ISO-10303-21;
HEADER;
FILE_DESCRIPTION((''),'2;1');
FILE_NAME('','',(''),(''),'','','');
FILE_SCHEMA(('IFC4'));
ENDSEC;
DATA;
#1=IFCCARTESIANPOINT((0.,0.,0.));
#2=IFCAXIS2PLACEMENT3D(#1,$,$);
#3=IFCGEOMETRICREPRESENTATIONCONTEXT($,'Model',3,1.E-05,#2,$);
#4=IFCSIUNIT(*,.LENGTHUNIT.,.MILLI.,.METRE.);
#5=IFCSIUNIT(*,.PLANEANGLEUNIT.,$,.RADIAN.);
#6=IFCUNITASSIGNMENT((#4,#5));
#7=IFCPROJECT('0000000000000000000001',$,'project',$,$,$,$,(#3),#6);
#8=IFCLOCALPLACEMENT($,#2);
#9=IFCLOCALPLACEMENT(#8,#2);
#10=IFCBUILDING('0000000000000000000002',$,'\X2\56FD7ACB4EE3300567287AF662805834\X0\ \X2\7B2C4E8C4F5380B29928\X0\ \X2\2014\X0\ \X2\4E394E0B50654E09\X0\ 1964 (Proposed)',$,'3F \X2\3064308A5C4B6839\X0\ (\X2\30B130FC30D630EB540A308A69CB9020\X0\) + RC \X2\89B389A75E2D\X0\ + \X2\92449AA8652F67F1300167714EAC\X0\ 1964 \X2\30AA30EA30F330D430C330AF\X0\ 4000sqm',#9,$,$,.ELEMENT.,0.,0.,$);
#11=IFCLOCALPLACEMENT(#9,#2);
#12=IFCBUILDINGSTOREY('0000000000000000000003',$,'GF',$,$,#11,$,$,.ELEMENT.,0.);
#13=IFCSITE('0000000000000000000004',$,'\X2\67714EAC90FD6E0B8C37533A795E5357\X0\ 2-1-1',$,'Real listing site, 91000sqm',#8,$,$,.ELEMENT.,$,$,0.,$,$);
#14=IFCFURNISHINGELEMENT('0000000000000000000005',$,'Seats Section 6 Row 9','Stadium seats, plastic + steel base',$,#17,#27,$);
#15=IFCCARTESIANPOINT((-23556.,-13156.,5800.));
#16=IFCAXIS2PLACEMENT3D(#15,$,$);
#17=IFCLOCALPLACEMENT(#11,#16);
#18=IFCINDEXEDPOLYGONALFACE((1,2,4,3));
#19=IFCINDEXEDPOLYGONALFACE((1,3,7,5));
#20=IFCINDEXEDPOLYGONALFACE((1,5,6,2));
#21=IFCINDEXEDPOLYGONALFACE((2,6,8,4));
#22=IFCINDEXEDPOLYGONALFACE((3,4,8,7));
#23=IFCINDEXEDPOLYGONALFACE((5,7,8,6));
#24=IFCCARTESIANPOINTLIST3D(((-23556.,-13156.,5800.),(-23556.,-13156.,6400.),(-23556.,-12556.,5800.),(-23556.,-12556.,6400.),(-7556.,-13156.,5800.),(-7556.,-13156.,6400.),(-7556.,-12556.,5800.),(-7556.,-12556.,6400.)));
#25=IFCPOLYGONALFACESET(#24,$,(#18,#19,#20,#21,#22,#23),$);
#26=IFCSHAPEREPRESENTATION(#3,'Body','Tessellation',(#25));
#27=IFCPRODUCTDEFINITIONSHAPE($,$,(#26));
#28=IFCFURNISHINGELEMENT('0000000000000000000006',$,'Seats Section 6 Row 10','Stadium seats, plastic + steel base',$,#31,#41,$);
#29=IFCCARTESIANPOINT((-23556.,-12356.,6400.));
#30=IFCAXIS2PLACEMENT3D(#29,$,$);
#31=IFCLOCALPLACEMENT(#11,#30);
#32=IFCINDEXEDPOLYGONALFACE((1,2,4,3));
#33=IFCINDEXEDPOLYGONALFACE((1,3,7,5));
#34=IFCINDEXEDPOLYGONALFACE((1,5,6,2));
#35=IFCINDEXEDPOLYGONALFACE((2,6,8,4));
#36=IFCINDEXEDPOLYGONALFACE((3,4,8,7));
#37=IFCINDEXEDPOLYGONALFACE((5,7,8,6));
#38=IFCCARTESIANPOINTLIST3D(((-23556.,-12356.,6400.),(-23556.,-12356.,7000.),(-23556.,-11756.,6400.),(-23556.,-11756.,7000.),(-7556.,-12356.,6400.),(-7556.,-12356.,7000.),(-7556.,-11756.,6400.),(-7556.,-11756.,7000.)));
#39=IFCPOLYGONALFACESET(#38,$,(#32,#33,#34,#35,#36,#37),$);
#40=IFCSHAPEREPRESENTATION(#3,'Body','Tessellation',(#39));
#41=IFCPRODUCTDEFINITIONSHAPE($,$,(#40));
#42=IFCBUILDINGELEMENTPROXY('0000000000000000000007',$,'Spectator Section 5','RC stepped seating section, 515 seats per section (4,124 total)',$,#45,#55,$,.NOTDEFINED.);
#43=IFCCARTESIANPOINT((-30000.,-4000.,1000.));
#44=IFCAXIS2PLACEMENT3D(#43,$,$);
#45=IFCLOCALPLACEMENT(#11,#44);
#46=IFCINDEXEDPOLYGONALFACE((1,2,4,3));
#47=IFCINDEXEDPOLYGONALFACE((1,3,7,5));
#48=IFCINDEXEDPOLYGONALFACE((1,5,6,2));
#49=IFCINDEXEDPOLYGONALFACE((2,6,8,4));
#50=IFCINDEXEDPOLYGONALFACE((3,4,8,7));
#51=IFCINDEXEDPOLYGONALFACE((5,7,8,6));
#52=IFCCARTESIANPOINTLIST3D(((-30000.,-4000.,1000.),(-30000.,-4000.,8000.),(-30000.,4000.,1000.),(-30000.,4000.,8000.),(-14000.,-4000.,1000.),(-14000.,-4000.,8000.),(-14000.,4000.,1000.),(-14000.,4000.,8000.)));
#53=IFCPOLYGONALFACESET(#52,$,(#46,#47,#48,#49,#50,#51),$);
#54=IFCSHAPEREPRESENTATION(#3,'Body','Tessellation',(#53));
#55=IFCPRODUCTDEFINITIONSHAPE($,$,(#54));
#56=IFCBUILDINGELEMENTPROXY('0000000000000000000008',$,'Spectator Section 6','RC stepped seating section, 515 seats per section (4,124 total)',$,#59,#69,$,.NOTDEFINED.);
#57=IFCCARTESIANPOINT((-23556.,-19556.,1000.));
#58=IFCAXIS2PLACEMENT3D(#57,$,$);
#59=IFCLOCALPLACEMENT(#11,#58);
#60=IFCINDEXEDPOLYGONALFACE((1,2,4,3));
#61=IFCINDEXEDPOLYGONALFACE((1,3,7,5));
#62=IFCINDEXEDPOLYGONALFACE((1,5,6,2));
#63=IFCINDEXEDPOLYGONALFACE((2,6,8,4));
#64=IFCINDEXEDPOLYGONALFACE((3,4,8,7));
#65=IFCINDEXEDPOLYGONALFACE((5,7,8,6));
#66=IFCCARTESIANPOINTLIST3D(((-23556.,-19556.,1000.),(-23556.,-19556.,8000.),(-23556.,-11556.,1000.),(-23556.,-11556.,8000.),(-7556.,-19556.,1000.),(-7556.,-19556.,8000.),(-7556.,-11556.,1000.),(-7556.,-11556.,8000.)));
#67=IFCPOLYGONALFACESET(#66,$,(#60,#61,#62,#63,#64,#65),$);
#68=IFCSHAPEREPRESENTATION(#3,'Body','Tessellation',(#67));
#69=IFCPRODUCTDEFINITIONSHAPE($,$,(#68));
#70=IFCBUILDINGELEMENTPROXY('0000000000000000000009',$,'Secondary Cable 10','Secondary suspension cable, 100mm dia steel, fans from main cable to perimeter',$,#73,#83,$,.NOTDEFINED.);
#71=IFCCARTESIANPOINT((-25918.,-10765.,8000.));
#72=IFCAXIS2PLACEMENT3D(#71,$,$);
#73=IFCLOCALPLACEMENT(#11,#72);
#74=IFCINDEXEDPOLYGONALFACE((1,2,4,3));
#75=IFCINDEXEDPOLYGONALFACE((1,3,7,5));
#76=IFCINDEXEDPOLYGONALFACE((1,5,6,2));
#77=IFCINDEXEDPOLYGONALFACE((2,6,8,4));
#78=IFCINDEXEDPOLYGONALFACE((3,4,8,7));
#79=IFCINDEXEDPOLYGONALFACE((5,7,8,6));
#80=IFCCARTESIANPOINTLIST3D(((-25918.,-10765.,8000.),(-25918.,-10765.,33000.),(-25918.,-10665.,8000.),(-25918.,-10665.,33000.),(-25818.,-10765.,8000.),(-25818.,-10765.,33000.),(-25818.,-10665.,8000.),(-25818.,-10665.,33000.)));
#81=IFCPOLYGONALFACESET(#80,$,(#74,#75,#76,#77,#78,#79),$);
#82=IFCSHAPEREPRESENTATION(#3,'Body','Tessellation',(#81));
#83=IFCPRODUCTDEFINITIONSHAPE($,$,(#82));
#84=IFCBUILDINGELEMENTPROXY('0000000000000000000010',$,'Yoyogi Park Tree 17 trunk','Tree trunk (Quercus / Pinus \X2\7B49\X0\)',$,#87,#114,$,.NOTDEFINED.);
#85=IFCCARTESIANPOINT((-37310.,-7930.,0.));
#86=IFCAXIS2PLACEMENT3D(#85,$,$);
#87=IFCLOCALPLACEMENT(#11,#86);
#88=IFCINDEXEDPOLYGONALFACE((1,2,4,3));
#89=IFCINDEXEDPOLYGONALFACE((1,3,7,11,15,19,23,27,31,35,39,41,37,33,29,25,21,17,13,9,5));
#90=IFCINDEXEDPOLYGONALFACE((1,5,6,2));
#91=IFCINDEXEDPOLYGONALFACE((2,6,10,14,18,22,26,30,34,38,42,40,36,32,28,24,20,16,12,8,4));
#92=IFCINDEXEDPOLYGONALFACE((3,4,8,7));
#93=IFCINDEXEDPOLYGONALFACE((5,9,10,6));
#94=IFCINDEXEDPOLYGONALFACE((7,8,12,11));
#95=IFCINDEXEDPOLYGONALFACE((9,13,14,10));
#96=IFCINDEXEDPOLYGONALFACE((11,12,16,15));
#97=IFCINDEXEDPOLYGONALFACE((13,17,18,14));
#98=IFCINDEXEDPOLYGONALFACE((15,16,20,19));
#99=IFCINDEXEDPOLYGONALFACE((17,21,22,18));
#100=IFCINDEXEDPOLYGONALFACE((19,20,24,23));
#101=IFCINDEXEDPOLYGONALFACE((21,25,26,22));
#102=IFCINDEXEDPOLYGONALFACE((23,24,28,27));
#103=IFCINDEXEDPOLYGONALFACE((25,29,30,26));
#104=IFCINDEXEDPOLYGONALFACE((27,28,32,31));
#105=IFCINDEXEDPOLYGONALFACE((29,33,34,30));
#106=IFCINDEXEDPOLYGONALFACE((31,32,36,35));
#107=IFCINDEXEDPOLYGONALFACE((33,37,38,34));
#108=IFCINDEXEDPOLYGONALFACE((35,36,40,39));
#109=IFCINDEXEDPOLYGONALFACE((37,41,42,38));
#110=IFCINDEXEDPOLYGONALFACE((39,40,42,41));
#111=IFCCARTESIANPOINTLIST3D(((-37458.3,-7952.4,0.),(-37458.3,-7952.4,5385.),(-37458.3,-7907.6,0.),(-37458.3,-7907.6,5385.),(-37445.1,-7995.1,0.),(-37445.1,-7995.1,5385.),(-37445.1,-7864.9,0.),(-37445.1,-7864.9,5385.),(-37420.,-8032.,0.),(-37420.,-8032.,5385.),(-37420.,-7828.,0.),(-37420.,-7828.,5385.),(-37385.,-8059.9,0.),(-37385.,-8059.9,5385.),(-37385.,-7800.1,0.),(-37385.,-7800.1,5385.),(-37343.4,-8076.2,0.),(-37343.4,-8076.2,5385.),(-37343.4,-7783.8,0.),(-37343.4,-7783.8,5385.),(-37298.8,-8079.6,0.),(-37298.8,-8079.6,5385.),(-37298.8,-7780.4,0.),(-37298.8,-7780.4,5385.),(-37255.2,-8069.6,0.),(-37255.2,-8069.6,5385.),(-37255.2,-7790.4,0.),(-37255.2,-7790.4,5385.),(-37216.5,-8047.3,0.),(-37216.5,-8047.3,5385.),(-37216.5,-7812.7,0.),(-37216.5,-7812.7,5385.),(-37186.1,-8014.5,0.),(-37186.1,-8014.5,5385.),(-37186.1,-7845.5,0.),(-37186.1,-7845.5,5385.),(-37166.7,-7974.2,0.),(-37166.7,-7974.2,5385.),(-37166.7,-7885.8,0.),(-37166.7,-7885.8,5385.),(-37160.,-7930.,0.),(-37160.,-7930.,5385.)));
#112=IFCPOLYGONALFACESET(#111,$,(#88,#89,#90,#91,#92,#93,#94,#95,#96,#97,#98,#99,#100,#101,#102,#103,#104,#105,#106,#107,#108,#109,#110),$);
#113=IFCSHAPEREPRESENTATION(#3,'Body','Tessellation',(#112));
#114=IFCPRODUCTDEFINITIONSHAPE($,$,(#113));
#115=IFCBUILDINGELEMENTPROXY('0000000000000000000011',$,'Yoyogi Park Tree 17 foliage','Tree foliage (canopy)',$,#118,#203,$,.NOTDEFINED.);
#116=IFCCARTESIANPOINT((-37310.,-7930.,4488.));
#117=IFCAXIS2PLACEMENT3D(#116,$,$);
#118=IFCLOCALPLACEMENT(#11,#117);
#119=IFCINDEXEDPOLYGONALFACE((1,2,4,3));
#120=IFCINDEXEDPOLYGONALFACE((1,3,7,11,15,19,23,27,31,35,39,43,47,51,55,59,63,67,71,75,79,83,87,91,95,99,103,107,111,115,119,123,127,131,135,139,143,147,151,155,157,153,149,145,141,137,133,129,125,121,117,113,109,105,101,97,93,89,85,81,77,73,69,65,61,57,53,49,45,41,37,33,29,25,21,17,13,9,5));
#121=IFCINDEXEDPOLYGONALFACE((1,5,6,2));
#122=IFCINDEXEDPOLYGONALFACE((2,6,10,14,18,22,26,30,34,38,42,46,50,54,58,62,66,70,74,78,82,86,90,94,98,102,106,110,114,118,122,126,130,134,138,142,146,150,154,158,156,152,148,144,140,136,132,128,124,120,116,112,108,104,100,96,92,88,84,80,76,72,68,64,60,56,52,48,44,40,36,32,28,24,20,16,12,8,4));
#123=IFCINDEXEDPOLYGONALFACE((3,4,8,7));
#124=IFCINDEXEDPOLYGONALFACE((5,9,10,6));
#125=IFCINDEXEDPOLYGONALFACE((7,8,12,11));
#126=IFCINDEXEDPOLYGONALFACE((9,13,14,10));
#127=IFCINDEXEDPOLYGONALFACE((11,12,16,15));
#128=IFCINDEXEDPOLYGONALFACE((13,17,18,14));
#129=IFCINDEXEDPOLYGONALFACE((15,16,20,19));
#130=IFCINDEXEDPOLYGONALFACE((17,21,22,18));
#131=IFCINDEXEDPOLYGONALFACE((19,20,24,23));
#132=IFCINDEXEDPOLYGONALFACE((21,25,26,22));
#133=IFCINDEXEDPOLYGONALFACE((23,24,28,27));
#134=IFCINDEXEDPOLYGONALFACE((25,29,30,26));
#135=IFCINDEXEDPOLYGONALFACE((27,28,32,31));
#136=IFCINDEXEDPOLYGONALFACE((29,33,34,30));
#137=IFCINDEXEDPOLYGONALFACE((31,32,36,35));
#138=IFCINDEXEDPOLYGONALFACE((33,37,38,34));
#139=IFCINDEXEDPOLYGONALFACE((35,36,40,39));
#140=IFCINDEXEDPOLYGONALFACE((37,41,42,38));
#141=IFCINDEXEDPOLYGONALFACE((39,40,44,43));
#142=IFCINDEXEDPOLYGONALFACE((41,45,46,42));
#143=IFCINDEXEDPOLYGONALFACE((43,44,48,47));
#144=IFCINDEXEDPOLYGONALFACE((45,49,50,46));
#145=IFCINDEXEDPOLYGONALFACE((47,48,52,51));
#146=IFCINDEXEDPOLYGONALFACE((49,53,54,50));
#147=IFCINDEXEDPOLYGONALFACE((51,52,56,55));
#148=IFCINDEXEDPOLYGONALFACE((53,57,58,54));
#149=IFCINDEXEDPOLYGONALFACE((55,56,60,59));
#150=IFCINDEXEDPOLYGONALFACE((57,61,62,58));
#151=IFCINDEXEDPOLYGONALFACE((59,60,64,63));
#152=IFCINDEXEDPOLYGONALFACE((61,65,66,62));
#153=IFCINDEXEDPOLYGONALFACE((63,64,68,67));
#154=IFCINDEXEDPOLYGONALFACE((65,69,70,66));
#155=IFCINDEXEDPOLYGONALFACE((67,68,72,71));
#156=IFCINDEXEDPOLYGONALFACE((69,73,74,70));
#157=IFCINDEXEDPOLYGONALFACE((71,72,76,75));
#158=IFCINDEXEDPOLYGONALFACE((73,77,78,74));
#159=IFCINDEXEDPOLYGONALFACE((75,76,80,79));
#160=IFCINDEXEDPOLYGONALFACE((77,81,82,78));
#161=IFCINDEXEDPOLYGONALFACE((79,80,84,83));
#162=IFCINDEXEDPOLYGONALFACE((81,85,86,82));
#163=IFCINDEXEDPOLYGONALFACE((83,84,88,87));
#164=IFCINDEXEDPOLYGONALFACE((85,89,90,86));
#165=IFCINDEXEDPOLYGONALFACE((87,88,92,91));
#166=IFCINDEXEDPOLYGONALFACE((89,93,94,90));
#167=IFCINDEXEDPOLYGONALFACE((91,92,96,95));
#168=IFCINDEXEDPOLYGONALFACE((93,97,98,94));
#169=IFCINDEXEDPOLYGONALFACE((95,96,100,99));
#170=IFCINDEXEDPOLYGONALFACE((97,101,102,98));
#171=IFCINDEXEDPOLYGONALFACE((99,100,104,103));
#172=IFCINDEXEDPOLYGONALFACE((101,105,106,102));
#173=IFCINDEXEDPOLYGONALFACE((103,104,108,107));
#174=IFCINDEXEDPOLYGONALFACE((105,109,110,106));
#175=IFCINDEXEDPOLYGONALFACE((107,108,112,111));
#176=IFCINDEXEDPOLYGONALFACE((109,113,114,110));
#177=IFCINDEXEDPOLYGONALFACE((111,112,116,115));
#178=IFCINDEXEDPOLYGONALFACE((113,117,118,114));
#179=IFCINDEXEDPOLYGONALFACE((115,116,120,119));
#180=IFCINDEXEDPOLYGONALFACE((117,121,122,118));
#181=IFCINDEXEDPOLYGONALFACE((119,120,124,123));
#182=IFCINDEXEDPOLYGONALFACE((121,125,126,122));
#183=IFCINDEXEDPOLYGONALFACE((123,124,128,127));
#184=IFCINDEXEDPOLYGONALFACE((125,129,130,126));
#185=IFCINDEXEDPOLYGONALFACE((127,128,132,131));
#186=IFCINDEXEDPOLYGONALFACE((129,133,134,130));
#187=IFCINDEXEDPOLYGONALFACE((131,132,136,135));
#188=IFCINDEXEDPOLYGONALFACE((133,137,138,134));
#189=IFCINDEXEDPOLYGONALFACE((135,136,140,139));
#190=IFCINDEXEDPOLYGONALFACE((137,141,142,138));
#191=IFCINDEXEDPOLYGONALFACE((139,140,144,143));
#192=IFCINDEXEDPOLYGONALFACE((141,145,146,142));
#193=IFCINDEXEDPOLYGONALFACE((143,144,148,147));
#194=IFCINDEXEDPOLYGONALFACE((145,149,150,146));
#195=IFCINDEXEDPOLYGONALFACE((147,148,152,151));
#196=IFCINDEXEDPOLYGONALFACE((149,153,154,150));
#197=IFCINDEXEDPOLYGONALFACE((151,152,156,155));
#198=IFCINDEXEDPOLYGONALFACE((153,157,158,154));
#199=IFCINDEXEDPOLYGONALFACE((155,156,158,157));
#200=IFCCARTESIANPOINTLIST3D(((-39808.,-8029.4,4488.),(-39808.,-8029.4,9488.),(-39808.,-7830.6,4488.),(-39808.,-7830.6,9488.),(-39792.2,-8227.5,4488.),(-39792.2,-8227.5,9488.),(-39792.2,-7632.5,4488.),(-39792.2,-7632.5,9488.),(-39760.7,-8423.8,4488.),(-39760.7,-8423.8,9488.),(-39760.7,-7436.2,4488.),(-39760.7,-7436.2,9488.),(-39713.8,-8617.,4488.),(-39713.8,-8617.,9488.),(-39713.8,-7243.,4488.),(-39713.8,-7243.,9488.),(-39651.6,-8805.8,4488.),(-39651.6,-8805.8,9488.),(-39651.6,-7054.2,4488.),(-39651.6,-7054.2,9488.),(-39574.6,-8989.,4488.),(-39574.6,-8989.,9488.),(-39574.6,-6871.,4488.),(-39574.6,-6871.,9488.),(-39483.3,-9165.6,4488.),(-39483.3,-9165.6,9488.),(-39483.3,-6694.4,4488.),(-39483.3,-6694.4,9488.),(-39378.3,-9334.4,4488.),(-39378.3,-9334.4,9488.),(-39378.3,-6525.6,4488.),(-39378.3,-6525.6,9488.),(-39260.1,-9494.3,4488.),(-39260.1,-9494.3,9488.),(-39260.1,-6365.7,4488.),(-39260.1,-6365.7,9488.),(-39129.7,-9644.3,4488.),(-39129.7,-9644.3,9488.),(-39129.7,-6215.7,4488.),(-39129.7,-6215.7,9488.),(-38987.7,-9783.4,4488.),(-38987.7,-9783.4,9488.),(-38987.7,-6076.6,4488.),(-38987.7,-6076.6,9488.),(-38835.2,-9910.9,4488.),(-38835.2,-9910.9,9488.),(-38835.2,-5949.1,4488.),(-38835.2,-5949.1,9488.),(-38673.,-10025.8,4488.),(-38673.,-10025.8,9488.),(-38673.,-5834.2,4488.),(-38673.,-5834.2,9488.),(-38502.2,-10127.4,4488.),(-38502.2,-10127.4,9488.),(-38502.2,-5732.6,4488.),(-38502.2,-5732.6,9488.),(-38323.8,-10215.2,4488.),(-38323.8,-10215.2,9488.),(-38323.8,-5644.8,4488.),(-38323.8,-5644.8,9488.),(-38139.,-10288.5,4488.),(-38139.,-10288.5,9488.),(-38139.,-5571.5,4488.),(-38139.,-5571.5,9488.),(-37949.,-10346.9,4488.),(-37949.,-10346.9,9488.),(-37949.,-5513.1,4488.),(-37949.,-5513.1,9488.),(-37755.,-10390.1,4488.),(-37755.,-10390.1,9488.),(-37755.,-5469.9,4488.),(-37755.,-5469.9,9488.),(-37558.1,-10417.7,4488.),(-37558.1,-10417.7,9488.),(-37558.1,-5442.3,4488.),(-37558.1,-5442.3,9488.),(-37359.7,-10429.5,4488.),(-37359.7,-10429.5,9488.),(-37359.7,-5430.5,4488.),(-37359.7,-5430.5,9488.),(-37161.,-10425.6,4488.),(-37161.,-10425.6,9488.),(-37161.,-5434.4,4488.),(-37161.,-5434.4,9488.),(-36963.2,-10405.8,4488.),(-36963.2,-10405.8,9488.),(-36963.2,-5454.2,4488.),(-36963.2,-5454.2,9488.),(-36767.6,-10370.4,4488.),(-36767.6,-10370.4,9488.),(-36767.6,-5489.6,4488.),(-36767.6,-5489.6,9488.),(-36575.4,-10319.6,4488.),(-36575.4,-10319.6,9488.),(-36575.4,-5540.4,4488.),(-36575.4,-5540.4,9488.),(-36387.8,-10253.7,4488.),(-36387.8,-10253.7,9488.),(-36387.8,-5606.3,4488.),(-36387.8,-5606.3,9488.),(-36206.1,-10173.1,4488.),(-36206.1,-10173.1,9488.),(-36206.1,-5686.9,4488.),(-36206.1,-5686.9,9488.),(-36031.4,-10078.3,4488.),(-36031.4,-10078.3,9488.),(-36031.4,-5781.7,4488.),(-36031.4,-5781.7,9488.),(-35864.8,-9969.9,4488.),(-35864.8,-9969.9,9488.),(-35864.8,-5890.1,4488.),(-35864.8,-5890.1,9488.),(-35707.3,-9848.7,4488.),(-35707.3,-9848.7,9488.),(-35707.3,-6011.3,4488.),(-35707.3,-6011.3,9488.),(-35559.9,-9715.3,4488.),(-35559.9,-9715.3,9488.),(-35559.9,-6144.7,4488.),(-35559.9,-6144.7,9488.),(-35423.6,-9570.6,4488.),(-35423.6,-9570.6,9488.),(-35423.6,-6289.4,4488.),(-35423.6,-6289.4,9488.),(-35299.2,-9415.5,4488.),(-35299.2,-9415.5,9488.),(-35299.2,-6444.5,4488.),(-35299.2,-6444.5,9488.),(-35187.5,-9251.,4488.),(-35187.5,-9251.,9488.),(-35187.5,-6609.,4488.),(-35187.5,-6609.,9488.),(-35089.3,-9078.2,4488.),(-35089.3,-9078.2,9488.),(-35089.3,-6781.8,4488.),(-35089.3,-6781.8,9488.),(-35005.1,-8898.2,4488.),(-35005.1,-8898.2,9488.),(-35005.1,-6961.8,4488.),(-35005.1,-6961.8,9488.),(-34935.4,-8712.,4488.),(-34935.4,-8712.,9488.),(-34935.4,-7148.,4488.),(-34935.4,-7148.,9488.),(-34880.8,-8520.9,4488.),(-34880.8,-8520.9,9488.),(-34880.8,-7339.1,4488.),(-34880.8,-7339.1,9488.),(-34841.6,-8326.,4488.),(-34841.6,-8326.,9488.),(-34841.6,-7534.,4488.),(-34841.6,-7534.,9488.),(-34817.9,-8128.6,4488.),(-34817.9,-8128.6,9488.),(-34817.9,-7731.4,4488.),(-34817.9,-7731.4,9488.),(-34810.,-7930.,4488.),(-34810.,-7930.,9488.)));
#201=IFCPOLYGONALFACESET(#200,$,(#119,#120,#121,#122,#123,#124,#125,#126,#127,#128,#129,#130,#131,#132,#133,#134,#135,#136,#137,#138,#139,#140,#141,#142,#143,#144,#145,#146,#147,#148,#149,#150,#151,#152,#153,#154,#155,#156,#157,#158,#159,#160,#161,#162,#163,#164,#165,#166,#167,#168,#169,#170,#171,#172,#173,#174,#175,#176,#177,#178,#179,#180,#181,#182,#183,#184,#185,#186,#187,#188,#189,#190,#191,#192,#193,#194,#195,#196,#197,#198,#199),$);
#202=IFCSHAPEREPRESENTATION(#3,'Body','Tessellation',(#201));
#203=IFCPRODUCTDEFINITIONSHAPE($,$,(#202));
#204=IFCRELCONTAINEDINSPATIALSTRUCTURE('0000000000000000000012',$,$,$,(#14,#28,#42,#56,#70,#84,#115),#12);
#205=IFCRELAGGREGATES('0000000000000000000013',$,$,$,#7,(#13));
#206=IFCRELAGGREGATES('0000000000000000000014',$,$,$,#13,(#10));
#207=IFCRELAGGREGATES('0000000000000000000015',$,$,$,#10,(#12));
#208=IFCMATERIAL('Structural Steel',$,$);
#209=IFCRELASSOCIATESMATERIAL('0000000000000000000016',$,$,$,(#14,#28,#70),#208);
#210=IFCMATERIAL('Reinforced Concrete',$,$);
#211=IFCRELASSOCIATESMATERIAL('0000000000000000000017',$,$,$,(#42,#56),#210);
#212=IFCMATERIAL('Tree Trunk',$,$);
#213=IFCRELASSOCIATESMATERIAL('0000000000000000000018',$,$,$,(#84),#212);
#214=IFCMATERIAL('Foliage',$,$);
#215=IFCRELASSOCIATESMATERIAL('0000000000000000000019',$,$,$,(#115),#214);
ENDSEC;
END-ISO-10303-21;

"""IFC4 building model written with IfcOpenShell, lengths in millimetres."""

from ifc_helpers import new_model, si_unit, frame, frame_2d, origin, origin_2d, place, context, project, spatial, rectangle, circle, extrude, material, element, save


model = new_model("IFC4")

# Units and contexts
model_context = context("Model", 3, precision=1e-05, world=origin())
ifc_project = project(units=[si_unit("LENGTHUNIT", "METRE", prefix="MILLI"), si_unit("PLANEANGLEUNIT", "RADIAN")], contexts=[model_context])

# Site, building, storey
site_placement = place(None, origin())
site = spatial("IfcSite", under=ifc_project, at=site_placement, Name="東京都渋谷区神南 2-1-1", ObjectType="Real listing site, 91000sqm", CompositionType="ELEMENT", RefElevation=0.0)
building_placement = place(site_placement, origin())
building = spatial("IfcBuilding", under=site, at=building_placement, Name="国立代々木競技場 第二体育館 — 丹下健三 1964 (Proposed)", ObjectType="3F つり屋根 (ケーブル吊り構造) + RC 観覧席 + 鉄骨支柱、東京 1964 オリンピック 4000sqm", CompositionType="ELEMENT", ElevationOfRefHeight=0.0, ElevationOfTerrain=0.0)
storey_placement = place(building_placement, origin())
storey = spatial("IfcBuildingStorey", under=building, at=storey_placement, Name="GF", CompositionType="ELEMENT", Elevation=0.0)

# Shared definitions
ifc_material_1 = material(Name="Structural Steel")

# Furnishing elements
furnishing_1_placement = place(storey_placement, frame((-23556.0, -13156.0, 5800.0)))
element("IfcFurnishingElement", 1, at=furnishing_1_placement, inside=storey, material=ifc_material_1, Name="Seats Section 6 Row 9", Description="Stadium seats, plastic + steel base", context=model_context, shape_type="SweptSolid", body=[
    extrude(rectangle(XDim=16000.0, YDim=600.0, at=frame_2d((8000.0, 300.0))), frame((-23556.0, -13156.0, 5800.0)), (0.0, 0.0, 1.0), 600.0),
])
furnishing_2_placement = place(storey_placement, frame((-23556.0, -12356.0, 6400.0)))
element("IfcFurnishingElement", 2, at=furnishing_2_placement, inside=storey, material=ifc_material_1, Name="Seats Section 6 Row 10", Description="Stadium seats, plastic + steel base", context=model_context, shape_type="SweptSolid", body=[
    extrude(rectangle(XDim=16000.0, YDim=600.0, at=frame_2d((8000.0, 300.0))), frame((-23556.0, -12356.0, 6400.0)), (0.0, 0.0, 1.0), 600.0),
])

# Building element proxies
ifc_material_2 = material(Name="Reinforced Concrete")
proxy_1_placement = place(storey_placement, frame((-30000.0, -4000.0, 1000.0)))
element("IfcBuildingElementProxy", 3, at=proxy_1_placement, inside=storey, material=ifc_material_2, Name="Spectator Section 5", Description="RC stepped seating section, 515 seats per section (4,124 total)", PredefinedType="NOTDEFINED", context=model_context, shape_type="SweptSolid", body=[
    extrude(rectangle(XDim=16000.0, YDim=8000.0, at=frame_2d((8000.0, 4000.0))), frame((-30000.0, -4000.0, 1000.0)), (0.0, 0.0, 1.0), 7000.0),
])
proxy_2_placement = place(storey_placement, frame((-23556.0, -19556.0, 1000.0)))
element("IfcBuildingElementProxy", 4, at=proxy_2_placement, inside=storey, material=ifc_material_2, Name="Spectator Section 6", Description="RC stepped seating section, 515 seats per section (4,124 total)", PredefinedType="NOTDEFINED", context=model_context, shape_type="SweptSolid", body=[
    extrude(rectangle(XDim=16000.0, YDim=8000.0, at=frame_2d((8000.0, 4000.0))), frame((-23556.0, -19556.0, 1000.0)), (0.0, 0.0, 1.0), 7000.0),
])
proxy_3_placement = place(storey_placement, frame((-25918.0, -10765.0, 8000.0)))
element("IfcBuildingElementProxy", 5, at=proxy_3_placement, inside=storey, material=ifc_material_1, Name="Secondary Cable 10", Description="Secondary suspension cable, 100mm dia steel, fans from main cable to perimeter", PredefinedType="NOTDEFINED", context=model_context, shape_type="SweptSolid", body=[
    extrude(rectangle(XDim=100.0, YDim=100.0, at=frame_2d((50.0, 50.0))), frame((-25918.0, -10765.0, 8000.0)), (0.0, 0.0, 1.0), 25000.0),
])
ifc_material_3 = material(Name="Tree Trunk")
proxy_4_placement = place(storey_placement, frame((-37310.0, -7930.0, 0.0)))
element("IfcBuildingElementProxy", 6, at=proxy_4_placement, inside=storey, material=ifc_material_3, Name="Yoyogi Park Tree 17 trunk", Description="Tree trunk (Quercus / Pinus 等)", PredefinedType="NOTDEFINED", context=model_context, shape_type="SweptSolid", body=[
    extrude(circle(Radius=150.0, at=origin_2d()), frame((-37310.0, -7930.0, 0.0)), (0.0, 0.0, 1.0), 5385.0),
])
ifc_material_4 = material(Name="Foliage")
proxy_5_placement = place(storey_placement, frame((-37310.0, -7930.0, 4488.0)))
element("IfcBuildingElementProxy", 7, at=proxy_5_placement, inside=storey, material=ifc_material_4, Name="Yoyogi Park Tree 17 foliage", Description="Tree foliage (canopy)", PredefinedType="NOTDEFINED", context=model_context, shape_type="SweptSolid", body=[
    extrude(circle(Radius=2500.0, at=origin_2d()), frame((-37310.0, -7930.0, 4488.0)), (0.0, 0.0, 1.0), 5000.0),
])

save(model, "model.ifc")
